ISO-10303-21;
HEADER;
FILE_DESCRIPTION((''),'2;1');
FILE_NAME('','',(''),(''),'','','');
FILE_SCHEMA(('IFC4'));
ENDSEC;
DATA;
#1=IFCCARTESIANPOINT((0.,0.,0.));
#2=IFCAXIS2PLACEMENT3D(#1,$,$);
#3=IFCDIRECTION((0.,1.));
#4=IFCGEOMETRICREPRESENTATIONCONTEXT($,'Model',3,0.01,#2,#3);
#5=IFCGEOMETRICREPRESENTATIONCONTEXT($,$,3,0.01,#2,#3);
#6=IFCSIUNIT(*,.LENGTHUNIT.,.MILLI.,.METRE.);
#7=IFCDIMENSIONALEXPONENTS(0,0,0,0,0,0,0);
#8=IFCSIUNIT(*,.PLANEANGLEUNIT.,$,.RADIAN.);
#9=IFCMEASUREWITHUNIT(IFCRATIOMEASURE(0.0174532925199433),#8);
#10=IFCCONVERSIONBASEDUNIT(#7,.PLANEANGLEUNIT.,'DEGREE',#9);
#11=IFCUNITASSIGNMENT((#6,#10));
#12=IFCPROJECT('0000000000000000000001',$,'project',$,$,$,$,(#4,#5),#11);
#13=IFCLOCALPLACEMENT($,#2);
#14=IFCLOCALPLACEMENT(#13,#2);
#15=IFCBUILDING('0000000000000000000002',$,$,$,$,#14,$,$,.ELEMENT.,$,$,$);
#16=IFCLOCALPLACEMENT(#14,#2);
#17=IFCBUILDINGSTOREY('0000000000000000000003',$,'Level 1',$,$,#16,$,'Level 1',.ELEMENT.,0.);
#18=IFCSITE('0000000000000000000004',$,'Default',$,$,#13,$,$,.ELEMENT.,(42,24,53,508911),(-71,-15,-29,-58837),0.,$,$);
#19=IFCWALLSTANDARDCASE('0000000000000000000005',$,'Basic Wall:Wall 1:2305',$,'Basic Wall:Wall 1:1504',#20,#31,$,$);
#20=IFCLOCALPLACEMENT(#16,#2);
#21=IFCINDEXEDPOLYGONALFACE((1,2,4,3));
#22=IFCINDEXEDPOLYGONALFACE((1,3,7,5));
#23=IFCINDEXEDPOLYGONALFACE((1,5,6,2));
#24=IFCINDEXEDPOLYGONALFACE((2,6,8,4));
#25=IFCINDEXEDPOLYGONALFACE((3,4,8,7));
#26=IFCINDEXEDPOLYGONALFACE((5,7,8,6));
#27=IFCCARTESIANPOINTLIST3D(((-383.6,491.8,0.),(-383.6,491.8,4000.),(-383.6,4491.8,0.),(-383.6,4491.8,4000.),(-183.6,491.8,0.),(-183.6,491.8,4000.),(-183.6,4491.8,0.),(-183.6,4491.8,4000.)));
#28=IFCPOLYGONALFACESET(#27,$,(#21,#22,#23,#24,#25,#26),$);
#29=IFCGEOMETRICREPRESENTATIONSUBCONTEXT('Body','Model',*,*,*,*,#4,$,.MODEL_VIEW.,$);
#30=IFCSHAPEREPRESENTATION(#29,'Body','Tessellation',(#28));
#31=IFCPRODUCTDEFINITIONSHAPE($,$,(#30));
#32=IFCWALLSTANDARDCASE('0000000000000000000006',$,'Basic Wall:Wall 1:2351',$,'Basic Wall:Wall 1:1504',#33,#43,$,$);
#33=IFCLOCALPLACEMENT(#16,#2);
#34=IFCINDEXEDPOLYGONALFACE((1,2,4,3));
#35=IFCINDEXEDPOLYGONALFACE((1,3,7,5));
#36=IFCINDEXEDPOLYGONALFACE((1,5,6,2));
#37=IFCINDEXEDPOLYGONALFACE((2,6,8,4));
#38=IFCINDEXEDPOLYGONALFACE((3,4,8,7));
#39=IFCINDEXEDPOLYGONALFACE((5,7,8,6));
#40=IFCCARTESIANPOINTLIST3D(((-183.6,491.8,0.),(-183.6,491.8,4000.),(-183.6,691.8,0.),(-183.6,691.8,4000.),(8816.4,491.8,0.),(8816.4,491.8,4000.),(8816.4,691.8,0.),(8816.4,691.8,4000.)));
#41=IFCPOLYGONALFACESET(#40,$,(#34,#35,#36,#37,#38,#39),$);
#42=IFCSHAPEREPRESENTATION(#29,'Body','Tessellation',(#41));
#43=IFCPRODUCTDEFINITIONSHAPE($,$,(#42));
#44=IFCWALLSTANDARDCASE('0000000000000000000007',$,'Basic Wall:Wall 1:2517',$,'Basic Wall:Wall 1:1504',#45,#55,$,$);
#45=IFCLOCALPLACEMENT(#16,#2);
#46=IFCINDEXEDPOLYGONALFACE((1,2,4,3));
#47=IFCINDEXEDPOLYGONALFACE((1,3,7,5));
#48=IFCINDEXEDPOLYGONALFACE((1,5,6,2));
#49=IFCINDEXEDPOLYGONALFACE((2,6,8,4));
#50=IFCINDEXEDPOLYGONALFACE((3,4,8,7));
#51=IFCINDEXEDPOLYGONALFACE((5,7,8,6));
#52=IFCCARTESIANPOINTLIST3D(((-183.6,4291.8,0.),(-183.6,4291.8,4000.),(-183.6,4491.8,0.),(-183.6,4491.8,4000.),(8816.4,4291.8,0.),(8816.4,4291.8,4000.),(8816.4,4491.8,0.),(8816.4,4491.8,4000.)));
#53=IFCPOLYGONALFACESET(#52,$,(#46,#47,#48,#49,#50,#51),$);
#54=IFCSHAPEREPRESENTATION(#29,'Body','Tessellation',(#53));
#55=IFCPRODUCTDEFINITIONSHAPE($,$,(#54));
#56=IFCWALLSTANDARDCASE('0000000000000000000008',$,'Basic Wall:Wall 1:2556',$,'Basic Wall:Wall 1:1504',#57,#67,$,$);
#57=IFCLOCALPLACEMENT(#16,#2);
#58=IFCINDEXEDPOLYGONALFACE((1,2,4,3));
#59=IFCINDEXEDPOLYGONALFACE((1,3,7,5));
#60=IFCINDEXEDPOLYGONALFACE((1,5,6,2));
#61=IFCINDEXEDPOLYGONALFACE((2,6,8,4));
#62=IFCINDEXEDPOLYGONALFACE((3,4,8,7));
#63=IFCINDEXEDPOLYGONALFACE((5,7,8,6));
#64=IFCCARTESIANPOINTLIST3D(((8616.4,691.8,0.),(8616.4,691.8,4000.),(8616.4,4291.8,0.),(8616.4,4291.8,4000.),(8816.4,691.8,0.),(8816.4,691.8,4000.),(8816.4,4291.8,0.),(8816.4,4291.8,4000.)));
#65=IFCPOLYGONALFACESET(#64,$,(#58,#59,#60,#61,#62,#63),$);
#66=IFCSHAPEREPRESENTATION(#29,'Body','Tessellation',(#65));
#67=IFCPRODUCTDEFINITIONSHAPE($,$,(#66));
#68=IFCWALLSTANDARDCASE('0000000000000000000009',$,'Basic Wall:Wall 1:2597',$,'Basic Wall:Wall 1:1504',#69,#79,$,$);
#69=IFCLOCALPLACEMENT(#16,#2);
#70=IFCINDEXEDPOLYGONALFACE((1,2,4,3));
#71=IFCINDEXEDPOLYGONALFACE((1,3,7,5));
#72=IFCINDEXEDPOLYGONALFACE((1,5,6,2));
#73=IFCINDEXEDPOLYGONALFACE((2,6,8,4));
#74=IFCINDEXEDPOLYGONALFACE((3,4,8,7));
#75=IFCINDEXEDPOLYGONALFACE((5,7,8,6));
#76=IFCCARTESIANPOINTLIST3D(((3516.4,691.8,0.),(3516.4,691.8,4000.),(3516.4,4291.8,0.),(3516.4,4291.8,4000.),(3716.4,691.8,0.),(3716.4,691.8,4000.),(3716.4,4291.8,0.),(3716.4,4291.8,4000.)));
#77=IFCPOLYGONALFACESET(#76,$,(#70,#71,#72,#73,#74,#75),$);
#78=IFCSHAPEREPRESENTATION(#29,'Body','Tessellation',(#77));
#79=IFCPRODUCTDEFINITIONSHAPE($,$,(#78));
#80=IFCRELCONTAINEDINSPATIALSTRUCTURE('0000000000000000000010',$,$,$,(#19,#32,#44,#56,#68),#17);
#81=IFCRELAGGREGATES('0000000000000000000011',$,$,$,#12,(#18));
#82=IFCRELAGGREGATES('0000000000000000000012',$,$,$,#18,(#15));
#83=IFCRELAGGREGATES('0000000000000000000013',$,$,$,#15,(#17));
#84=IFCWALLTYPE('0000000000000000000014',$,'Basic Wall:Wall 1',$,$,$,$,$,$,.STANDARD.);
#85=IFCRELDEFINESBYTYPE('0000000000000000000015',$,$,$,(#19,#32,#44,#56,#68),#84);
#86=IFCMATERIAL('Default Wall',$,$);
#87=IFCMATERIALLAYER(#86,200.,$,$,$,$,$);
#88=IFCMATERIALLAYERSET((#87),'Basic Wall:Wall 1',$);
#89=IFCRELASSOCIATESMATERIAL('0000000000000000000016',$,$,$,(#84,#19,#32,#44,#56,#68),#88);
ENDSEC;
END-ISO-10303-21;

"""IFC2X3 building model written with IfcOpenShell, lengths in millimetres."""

from ifc_helpers import new_model, entity, si_unit, converted_unit, direction, frame, frame_2d, origin, place, context, subcontext, project, spatial, rectangle, extrude, material, layer, layer_set, layer_usage, type_object, element, save


model = new_model("IFC2X3")

# Units and contexts
model_context = context("Model", 3, precision=0.01, world=origin(), true_north=direction((0.0, 1.0)))
context_of_model = context(None, 3, precision=0.01, world=origin(), true_north=direction((0.0, 1.0)))
body_context = subcontext(model_context, "Body", "Model", "MODEL_VIEW")
ifc_project = project(units=[si_unit("LENGTHUNIT", "METRE", prefix="MILLI"), converted_unit("PLANEANGLEUNIT", "DEGREE", entity("IfcRatioMeasure", 0.0174532925199433), si_unit("PLANEANGLEUNIT", "RADIAN"), dimensions=[0, 0, 0, 0, 0, 0, 0])], contexts=[model_context, context_of_model])

# Site, building, storey
site_placement = place(None, origin())
site = spatial("IfcSite", under=ifc_project, at=site_placement, Name="Default", CompositionType="ELEMENT", RefLatitude=(42, 24, 53, 508911), RefLongitude=(-71, -15, -29, -58837), RefElevation=0.0)
building_placement = place(site_placement, origin())
building = spatial("IfcBuilding", under=site, at=building_placement, CompositionType="ELEMENT")
storey_placement = place(building_placement, origin())
storey = spatial("IfcBuildingStorey", under=building, at=storey_placement, Name="Level 1", LongName="Level 1", CompositionType="ELEMENT", Elevation=0.0)

# Walls
ifc_material = material(Name="Default Wall")
ifc_layer = layer(ifc_material, 200.0)
ifc_layer_set = layer_set([ifc_layer], Name="Basic Wall:Wall 1")
ifc_layer_usage_1 = layer_usage(ifc_layer_set, "AXIS2", "NEGATIVE", 100.0)
wall_type = type_object("IfcWallType", Name="Basic Wall:Wall 1", PredefinedType="STANDARD", material=ifc_layer_set)
wall_1_placement = place(storey_placement, frame((-283.6, 4491.8, 0.0), z_axis=(0.0, 0.0, 1.0), x_axis=(0.0, -1.0, 0.0)))
element("IfcWallStandardCase", 1, at=wall_1_placement, inside=storey, type_object=wall_type, material=ifc_layer_usage_1, Name="Basic Wall:Wall 1:2305", ObjectType="Basic Wall:Wall 1:1504", context=body_context, shape_type="SweptSolid", body=[
    extrude(rectangle(XDim=4000.0, YDim=200.0, at=frame_2d((2000.0, 0.0), x_axis=(-1.0, 0.0))), origin(), (0.0, 0.0, 1.0), 4000.0),
])
ifc_layer_usage_2 = layer_usage(ifc_layer_set, "AXIS2", "NEGATIVE", 100.0)
wall_2_placement = place(storey_placement, frame((-183.6, 591.8, 0.0)))
element("IfcWallStandardCase", 2, at=wall_2_placement, inside=storey, type_object=wall_type, material=ifc_layer_usage_2, Name="Basic Wall:Wall 1:2351", ObjectType="Basic Wall:Wall 1:1504", context=body_context, shape_type="SweptSolid", body=[
    extrude(rectangle(XDim=9000.0, YDim=200.0, at=frame_2d((4500.0, 0.0), x_axis=(-1.0, 0.0))), origin(), (0.0, 0.0, 1.0), 4000.0),
])
ifc_layer_usage_3 = layer_usage(ifc_layer_set, "AXIS2", "NEGATIVE", 100.0)
wall_3_placement = place(storey_placement, frame((-183.6, 4391.8, 0.0)))
element("IfcWallStandardCase", 3, at=wall_3_placement, inside=storey, type_object=wall_type, material=ifc_layer_usage_3, Name="Basic Wall:Wall 1:2517", ObjectType="Basic Wall:Wall 1:1504", context=body_context, shape_type="SweptSolid", body=[
    extrude(rectangle(XDim=9000.0, YDim=200.0, at=frame_2d((4500.0, 0.0), x_axis=(-1.0, 0.0))), origin(), (0.0, 0.0, 1.0), 4000.0),
])
ifc_layer_usage_4 = layer_usage(ifc_layer_set, "AXIS2", "NEGATIVE", 100.0)
wall_4_placement = place(storey_placement, frame((8716.4, 4291.8, 0.0), z_axis=(0.0, 0.0, 1.0), x_axis=(0.0, -1.0, 0.0)))
element("IfcWallStandardCase", 4, at=wall_4_placement, inside=storey, type_object=wall_type, material=ifc_layer_usage_4, Name="Basic Wall:Wall 1:2556", ObjectType="Basic Wall:Wall 1:1504", context=body_context, shape_type="SweptSolid", body=[
    extrude(rectangle(XDim=3600.0, YDim=200.0, at=frame_2d((1800.0, 0.0), x_axis=(-1.0, 0.0))), origin(), (0.0, 0.0, 1.0), 4000.0),
])
ifc_layer_usage_5 = layer_usage(ifc_layer_set, "AXIS2", "NEGATIVE", 100.0)
wall_5_placement = place(storey_placement, frame((3616.4, 691.8, 0.0), z_axis=(0.0, 0.0, 1.0), x_axis=(0.0, 1.0, 0.0)))
element("IfcWallStandardCase", 5, at=wall_5_placement, inside=storey, type_object=wall_type, material=ifc_layer_usage_5, Name="Basic Wall:Wall 1:2597", ObjectType="Basic Wall:Wall 1:1504", context=body_context, shape_type="SweptSolid", body=[
    extrude(rectangle(XDim=3600.0, YDim=200.0, at=frame_2d((1800.0, 0.0), x_axis=(-1.0, 0.0))), origin(), (0.0, 0.0, 1.0), 4000.0),
])

save(model, "model.ifc")
